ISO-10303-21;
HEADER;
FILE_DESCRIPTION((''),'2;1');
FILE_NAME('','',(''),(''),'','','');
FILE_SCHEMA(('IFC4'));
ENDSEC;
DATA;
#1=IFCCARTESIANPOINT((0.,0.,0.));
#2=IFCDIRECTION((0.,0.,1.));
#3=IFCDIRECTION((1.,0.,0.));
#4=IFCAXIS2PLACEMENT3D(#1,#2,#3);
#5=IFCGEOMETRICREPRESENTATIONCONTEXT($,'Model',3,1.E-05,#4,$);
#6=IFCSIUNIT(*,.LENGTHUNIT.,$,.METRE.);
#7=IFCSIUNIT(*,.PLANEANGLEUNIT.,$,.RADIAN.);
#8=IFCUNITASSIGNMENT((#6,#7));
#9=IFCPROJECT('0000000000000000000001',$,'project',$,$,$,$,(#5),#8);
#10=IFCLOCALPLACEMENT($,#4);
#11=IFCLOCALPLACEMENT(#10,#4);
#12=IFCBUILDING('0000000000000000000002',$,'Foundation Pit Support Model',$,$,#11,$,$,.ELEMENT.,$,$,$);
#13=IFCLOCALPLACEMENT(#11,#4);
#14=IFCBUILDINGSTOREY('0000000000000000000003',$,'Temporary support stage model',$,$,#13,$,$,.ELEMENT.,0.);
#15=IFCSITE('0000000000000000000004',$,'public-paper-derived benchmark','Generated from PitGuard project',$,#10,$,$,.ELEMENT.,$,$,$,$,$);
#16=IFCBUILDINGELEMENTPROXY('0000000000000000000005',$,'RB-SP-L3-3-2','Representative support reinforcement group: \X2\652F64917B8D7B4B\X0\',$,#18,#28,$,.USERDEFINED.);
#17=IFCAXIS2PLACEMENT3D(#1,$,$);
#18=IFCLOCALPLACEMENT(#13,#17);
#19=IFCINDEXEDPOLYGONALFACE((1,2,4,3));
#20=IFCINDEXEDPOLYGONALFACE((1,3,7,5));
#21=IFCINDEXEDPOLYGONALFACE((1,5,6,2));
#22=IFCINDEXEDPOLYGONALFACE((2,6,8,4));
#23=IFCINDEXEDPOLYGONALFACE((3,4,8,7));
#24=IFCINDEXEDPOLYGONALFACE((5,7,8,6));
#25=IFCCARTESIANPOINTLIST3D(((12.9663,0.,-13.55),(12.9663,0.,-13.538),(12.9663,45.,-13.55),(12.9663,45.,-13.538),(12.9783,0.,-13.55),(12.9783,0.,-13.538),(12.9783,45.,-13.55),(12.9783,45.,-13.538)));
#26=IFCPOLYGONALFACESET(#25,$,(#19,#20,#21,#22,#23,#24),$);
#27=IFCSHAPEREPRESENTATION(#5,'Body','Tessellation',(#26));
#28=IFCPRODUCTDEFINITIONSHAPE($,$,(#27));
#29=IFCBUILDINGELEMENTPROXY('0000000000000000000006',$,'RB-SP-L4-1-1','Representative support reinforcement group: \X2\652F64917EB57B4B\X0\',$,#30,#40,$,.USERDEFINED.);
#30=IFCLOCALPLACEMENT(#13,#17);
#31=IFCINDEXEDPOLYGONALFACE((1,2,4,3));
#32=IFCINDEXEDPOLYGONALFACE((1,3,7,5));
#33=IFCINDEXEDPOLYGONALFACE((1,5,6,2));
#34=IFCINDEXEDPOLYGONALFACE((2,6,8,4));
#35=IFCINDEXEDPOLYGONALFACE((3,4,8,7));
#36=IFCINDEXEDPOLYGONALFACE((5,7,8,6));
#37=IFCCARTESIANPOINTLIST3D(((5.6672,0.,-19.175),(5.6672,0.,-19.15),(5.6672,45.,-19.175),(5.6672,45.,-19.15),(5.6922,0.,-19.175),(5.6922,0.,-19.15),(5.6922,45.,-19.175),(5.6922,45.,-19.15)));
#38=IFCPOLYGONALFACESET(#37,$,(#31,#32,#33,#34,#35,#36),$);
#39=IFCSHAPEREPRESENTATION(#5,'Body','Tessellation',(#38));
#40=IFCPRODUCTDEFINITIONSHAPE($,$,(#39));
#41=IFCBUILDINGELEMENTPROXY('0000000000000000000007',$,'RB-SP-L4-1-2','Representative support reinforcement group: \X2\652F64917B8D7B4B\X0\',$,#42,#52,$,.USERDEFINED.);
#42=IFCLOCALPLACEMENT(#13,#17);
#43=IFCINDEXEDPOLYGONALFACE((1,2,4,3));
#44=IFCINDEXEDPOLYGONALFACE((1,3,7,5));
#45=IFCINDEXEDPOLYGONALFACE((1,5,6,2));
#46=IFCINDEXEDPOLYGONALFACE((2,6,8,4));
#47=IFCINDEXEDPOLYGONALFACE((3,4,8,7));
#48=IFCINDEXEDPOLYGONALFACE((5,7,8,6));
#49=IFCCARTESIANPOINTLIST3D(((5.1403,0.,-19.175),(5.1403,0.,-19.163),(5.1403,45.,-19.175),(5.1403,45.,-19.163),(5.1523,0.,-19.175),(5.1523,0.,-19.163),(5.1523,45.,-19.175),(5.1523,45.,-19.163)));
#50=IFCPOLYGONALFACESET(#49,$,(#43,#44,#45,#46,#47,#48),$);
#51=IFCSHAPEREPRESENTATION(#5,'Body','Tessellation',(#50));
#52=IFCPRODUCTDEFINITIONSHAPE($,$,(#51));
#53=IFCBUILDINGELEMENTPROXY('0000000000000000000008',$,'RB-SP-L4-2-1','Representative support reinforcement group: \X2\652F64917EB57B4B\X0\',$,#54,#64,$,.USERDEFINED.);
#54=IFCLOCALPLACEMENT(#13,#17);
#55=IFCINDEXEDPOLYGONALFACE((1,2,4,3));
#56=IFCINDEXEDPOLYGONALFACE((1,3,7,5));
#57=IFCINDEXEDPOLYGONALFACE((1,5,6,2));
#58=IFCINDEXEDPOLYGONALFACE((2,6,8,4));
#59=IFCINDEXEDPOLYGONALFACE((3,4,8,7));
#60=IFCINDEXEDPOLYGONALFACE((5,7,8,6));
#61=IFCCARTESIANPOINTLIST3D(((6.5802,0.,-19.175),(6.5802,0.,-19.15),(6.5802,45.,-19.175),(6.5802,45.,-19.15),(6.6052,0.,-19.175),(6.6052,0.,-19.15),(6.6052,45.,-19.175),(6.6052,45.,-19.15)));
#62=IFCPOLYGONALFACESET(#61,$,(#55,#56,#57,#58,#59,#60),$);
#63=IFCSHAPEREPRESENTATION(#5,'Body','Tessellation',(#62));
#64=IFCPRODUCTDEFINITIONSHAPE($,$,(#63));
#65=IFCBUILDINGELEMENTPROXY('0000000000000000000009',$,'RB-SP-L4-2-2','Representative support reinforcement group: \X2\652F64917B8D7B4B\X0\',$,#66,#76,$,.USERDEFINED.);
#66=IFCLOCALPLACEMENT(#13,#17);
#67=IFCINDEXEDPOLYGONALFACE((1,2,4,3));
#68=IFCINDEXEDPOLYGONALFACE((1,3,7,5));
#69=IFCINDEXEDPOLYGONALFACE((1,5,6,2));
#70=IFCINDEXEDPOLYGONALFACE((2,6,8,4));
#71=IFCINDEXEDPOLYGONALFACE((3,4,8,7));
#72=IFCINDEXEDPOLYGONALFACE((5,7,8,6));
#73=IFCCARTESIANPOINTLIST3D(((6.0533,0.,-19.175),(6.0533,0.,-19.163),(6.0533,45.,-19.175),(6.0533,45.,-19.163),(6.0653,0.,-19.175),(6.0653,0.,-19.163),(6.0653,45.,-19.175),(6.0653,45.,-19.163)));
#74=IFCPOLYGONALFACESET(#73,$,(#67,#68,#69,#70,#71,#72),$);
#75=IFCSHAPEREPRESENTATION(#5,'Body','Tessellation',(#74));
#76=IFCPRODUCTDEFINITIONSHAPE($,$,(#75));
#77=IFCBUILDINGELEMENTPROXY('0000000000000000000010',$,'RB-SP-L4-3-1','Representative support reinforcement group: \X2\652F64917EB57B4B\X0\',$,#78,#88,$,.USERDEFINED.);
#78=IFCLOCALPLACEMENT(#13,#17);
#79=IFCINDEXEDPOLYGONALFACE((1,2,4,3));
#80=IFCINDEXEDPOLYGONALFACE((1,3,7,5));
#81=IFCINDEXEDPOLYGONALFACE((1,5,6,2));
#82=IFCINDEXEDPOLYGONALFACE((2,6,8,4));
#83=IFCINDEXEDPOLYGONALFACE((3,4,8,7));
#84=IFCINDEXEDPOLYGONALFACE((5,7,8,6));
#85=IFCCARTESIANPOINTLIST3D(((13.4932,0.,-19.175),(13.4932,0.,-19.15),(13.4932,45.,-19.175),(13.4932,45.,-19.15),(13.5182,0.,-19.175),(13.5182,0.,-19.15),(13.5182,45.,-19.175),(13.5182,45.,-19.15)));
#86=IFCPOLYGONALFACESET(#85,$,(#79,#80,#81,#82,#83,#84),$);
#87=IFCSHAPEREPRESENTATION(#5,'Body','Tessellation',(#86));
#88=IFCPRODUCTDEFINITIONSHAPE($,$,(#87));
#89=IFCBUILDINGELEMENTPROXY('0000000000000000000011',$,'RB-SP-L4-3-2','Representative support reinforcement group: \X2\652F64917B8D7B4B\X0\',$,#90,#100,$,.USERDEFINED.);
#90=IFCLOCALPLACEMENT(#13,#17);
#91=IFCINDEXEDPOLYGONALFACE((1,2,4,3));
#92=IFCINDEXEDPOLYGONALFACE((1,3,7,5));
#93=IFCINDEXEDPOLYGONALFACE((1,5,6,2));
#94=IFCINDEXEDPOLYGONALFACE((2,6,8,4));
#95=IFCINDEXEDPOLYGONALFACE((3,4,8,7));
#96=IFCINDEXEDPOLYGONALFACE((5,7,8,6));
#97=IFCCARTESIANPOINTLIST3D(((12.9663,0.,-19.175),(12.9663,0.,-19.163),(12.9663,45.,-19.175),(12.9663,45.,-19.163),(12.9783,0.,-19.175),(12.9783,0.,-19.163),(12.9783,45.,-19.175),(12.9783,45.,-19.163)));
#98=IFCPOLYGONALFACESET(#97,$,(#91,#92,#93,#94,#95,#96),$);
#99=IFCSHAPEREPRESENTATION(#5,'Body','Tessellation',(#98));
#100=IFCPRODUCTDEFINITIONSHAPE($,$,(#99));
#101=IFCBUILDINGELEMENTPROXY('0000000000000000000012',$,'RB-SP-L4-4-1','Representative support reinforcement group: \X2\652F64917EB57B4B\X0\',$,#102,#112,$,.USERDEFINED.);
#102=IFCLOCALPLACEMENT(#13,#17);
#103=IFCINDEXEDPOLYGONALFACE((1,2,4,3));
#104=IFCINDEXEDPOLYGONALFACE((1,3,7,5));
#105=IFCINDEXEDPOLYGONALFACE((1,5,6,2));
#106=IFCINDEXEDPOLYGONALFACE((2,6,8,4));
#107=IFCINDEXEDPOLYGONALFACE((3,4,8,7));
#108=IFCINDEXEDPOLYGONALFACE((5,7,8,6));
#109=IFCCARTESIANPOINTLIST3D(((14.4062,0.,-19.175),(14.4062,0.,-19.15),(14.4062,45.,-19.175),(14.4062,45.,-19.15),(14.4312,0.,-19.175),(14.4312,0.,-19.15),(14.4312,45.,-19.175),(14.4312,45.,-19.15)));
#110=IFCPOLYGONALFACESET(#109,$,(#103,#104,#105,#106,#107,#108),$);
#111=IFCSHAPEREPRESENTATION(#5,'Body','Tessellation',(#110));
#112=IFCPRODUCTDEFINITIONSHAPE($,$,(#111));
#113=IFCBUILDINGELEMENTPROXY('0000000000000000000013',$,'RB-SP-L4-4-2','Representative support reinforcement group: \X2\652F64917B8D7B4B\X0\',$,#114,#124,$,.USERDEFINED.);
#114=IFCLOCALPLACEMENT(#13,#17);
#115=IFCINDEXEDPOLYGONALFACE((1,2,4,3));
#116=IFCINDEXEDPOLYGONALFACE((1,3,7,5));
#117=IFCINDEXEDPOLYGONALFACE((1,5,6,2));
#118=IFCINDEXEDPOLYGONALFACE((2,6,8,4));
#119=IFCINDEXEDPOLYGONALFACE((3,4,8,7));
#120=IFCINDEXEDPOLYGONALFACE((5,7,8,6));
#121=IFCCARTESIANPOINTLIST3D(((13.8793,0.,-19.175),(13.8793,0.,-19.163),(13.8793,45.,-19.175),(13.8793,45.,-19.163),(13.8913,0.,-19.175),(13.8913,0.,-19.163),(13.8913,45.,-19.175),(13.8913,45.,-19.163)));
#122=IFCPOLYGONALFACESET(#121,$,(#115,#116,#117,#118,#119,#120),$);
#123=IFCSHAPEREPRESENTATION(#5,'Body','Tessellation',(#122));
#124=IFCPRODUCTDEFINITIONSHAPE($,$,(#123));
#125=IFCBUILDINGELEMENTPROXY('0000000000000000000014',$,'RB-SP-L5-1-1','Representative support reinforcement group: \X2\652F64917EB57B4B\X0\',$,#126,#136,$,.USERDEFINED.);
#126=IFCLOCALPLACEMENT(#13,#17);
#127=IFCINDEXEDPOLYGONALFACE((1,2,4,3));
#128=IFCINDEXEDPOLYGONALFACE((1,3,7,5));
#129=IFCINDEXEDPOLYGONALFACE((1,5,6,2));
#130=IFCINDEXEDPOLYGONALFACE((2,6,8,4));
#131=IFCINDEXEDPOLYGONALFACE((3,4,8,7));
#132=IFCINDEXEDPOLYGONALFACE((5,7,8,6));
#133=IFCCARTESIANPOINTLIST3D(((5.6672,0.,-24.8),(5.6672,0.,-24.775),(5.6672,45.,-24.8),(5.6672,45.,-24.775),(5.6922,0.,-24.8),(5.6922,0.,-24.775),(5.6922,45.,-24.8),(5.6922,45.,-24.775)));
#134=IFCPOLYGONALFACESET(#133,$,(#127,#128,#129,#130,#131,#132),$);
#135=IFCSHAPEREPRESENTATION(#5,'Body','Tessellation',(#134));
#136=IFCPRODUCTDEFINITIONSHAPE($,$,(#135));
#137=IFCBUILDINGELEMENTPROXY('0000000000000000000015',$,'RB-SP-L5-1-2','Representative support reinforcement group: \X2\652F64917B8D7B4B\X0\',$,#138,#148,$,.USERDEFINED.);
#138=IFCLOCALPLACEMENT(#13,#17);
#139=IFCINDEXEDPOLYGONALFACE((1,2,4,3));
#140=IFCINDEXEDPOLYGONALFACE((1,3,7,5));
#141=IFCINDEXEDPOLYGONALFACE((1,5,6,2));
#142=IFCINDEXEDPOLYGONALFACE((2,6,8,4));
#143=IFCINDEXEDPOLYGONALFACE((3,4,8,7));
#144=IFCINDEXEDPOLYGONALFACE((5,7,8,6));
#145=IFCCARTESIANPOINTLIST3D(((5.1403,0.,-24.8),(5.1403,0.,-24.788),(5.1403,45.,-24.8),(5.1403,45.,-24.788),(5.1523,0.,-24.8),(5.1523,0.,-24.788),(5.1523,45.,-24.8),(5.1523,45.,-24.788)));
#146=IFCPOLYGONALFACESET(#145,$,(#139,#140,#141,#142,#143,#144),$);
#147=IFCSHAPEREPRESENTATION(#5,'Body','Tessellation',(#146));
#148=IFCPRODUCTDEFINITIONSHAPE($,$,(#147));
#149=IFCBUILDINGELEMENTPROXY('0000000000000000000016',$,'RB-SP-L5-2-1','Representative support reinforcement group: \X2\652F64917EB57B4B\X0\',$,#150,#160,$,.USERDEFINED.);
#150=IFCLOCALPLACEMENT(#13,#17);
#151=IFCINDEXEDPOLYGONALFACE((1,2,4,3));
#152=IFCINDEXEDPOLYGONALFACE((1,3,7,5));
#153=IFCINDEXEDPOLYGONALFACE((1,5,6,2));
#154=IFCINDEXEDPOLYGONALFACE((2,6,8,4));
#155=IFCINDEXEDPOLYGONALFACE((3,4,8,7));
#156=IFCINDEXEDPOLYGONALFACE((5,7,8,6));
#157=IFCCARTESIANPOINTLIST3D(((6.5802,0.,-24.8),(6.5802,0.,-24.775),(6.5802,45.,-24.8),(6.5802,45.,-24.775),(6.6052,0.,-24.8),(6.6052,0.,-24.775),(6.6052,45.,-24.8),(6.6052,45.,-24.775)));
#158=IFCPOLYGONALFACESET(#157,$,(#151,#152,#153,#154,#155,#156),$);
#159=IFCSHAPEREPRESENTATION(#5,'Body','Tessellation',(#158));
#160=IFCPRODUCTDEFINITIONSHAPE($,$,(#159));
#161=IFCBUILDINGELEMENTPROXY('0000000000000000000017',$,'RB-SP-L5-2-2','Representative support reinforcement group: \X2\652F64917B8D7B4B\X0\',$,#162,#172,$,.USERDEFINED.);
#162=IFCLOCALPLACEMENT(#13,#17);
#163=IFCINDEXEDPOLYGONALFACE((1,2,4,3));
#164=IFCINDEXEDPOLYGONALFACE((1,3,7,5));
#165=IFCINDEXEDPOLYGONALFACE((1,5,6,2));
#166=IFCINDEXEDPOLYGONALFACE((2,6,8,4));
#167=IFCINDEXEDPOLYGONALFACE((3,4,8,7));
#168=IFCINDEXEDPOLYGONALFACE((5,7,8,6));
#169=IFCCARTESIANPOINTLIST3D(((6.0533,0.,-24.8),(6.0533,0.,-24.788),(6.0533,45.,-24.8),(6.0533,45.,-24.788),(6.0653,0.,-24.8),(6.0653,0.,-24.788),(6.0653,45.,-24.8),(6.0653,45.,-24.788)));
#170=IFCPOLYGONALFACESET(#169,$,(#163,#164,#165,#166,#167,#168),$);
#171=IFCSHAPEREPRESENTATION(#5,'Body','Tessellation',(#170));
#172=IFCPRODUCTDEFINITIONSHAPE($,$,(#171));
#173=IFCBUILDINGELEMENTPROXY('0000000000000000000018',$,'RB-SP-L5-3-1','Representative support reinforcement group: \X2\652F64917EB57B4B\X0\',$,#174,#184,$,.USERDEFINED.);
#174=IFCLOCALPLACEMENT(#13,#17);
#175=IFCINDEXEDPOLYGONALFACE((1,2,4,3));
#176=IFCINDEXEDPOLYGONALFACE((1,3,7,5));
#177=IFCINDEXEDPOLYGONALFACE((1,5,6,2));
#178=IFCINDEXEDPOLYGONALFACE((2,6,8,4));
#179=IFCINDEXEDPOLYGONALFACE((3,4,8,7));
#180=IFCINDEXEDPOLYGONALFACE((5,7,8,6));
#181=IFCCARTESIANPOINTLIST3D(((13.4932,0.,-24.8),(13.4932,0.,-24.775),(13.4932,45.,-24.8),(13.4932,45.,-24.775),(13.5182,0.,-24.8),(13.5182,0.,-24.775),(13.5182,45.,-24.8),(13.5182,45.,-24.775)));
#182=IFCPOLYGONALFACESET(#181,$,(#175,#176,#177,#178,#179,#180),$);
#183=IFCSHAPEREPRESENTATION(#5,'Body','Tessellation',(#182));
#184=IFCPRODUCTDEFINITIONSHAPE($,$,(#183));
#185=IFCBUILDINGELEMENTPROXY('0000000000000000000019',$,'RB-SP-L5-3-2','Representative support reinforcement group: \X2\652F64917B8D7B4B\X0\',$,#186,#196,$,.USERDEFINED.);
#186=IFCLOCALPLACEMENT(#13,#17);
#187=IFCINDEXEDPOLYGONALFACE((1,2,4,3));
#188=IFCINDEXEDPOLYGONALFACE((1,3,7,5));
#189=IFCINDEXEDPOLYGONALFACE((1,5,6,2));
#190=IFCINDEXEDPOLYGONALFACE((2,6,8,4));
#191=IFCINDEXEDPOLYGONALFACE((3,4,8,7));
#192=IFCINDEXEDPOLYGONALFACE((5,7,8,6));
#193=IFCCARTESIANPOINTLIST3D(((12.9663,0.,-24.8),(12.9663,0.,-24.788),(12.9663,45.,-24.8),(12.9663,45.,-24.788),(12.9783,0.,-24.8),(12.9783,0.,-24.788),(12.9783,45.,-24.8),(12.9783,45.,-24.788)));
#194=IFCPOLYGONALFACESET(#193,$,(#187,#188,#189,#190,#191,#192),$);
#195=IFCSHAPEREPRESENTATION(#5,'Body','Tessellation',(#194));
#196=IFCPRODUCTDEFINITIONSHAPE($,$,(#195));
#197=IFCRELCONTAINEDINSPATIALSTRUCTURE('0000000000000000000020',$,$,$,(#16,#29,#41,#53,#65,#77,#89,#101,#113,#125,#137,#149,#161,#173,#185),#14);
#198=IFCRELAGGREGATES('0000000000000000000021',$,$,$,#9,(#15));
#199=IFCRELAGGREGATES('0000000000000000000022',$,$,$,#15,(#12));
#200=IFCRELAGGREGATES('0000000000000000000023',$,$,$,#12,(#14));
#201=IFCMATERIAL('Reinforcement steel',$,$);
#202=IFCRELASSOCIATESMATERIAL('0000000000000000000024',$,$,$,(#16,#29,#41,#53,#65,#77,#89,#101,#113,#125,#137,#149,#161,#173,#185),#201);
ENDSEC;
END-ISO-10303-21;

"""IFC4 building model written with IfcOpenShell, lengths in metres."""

from ifc_helpers import new_model, si_unit, frame, origin_with_axes, origin_2d, place, context, project, spatial, rectangle, extrude, material, element, save


model = new_model("IFC4")

# Units and contexts
model_context = context("Model", 3, precision=1e-05, world=origin_with_axes())
ifc_project = project(units=[si_unit("LENGTHUNIT", "METRE"), si_unit("PLANEANGLEUNIT", "RADIAN")], contexts=[model_context])

# Site, building, storey
site_placement = place(None, origin_with_axes())
site = spatial("IfcSite", under=ifc_project, at=site_placement, Name="public-paper-derived benchmark", Description="Generated from PitGuard project", CompositionType="ELEMENT")
building_placement = place(site_placement, origin_with_axes())
building = spatial("IfcBuilding", under=site, at=building_placement, Name="Foundation Pit Support Model", CompositionType="ELEMENT")
storey_placement = place(building_placement, origin_with_axes())
storey = spatial("IfcBuildingStorey", under=building, at=storey_placement, Name="Temporary support stage model", CompositionType="ELEMENT", Elevation=0.0)

# Building element proxies
ifc_material_1 = material(Name="Reinforcement steel")
proxy_1_placement = place(storey_placement, frame((12.9723, 22.5, -13.55), z_axis=(0.0, 0.0, 1.0), x_axis=(0.0, 1.0, 0.0)))
element("IfcBuildingElementProxy", 1, at=proxy_1_placement, inside=storey, material=ifc_material_1, Name="RB-SP-L3-3-2", Description="Representative support reinforcement group: 支撑箍筋", PredefinedType="USERDEFINED", context=model_context, shape_type="SweptSolid", body=[
    extrude(rectangle(XDim=45.0, YDim=0.012, at=origin_2d()), origin_with_axes(), (0.0, 0.0, 1.0), 0.012),
])
proxy_2_placement = place(storey_placement, frame((5.6797, 22.5, -19.175), z_axis=(0.0, 0.0, 1.0), x_axis=(0.0, 1.0, 0.0)))
element("IfcBuildingElementProxy", 2, at=proxy_2_placement, inside=storey, material=ifc_material_1, Name="RB-SP-L4-1-1", Description="Representative support reinforcement group: 支撑纵筋", PredefinedType="USERDEFINED", context=model_context, shape_type="SweptSolid", body=[
    extrude(rectangle(XDim=45.0, YDim=0.025, at=origin_2d()), origin_with_axes(), (0.0, 0.0, 1.0), 0.025),
])
proxy_3_placement = place(storey_placement, frame((5.1463, 22.5, -19.175), z_axis=(0.0, 0.0, 1.0), x_axis=(0.0, 1.0, 0.0)))
element("IfcBuildingElementProxy", 3, at=proxy_3_placement, inside=storey, material=ifc_material_1, Name="RB-SP-L4-1-2", Description="Representative support reinforcement group: 支撑箍筋", PredefinedType="USERDEFINED", context=model_context, shape_type="SweptSolid", body=[
    extrude(rectangle(XDim=45.0, YDim=0.012, at=origin_2d()), origin_with_axes(), (0.0, 0.0, 1.0), 0.012),
])
proxy_4_placement = place(storey_placement, frame((6.5927, 22.5, -19.175), z_axis=(0.0, 0.0, 1.0), x_axis=(0.0, 1.0, 0.0)))
element("IfcBuildingElementProxy", 4, at=proxy_4_placement, inside=storey, material=ifc_material_1, Name="RB-SP-L4-2-1", Description="Representative support reinforcement group: 支撑纵筋", PredefinedType="USERDEFINED", context=model_context, shape_type="SweptSolid", body=[
    extrude(rectangle(XDim=45.0, YDim=0.025, at=origin_2d()), origin_with_axes(), (0.0, 0.0, 1.0), 0.025),
])
proxy_5_placement = place(storey_placement, frame((6.0593, 22.5, -19.175), z_axis=(0.0, 0.0, 1.0), x_axis=(0.0, 1.0, 0.0)))
element("IfcBuildingElementProxy", 5, at=proxy_5_placement, inside=storey, material=ifc_material_1, Name="RB-SP-L4-2-2", Description="Representative support reinforcement group: 支撑箍筋", PredefinedType="USERDEFINED", context=model_context, shape_type="SweptSolid", body=[
    extrude(rectangle(XDim=45.0, YDim=0.012, at=origin_2d()), origin_with_axes(), (0.0, 0.0, 1.0), 0.012),
])
proxy_6_placement = place(storey_placement, frame((13.5057, 22.5, -19.175), z_axis=(0.0, 0.0, 1.0), x_axis=(0.0, 1.0, 0.0)))
element("IfcBuildingElementProxy", 6, at=proxy_6_placement, inside=storey, material=ifc_material_1, Name="RB-SP-L4-3-1", Description="Representative support reinforcement group: 支撑纵筋", PredefinedType="USERDEFINED", context=model_context, shape_type="SweptSolid", body=[
    extrude(rectangle(XDim=45.0, YDim=0.025, at=origin_2d()), origin_with_axes(), (0.0, 0.0, 1.0), 0.025),
])
proxy_7_placement = place(storey_placement, frame((12.9723, 22.5, -19.175), z_axis=(0.0, 0.0, 1.0), x_axis=(0.0, 1.0, 0.0)))
element("IfcBuildingElementProxy", 7, at=proxy_7_placement, inside=storey, material=ifc_material_1, Name="RB-SP-L4-3-2", Description="Representative support reinforcement group: 支撑箍筋", PredefinedType="USERDEFINED", context=model_context, shape_type="SweptSolid", body=[
    extrude(rectangle(XDim=45.0, YDim=0.012, at=origin_2d()), origin_with_axes(), (0.0, 0.0, 1.0), 0.012),
])
proxy_8_placement = place(storey_placement, frame((14.4187, 22.5, -19.175), z_axis=(0.0, 0.0, 1.0), x_axis=(0.0, 1.0, 0.0)))
element("IfcBuildingElementProxy", 8, at=proxy_8_placement, inside=storey, material=ifc_material_1, Name="RB-SP-L4-4-1", Description="Representative support reinforcement group: 支撑纵筋", PredefinedType="USERDEFINED", context=model_context, shape_type="SweptSolid", body=[
    extrude(rectangle(XDim=45.0, YDim=0.025, at=origin_2d()), origin_with_axes(), (0.0, 0.0, 1.0), 0.025),
])
proxy_9_placement = place(storey_placement, frame((13.8853, 22.5, -19.175), z_axis=(0.0, 0.0, 1.0), x_axis=(0.0, 1.0, 0.0)))
element("IfcBuildingElementProxy", 9, at=proxy_9_placement, inside=storey, material=ifc_material_1, Name="RB-SP-L4-4-2", Description="Representative support reinforcement group: 支撑箍筋", PredefinedType="USERDEFINED", context=model_context, shape_type="SweptSolid", body=[
    extrude(rectangle(XDim=45.0, YDim=0.012, at=origin_2d()), origin_with_axes(), (0.0, 0.0, 1.0), 0.012),
])
proxy_10_placement = place(storey_placement, frame((5.6797, 22.5, -24.8), z_axis=(0.0, 0.0, 1.0), x_axis=(0.0, 1.0, 0.0)))
element("IfcBuildingElementProxy", 10, at=proxy_10_placement, inside=storey, material=ifc_material_1, Name="RB-SP-L5-1-1", Description="Representative support reinforcement group: 支撑纵筋", PredefinedType="USERDEFINED", context=model_context, shape_type="SweptSolid", body=[
    extrude(rectangle(XDim=45.0, YDim=0.025, at=origin_2d()), origin_with_axes(), (0.0, 0.0, 1.0), 0.025),
])
proxy_11_placement = place(storey_placement, frame((5.1463, 22.5, -24.8), z_axis=(0.0, 0.0, 1.0), x_axis=(0.0, 1.0, 0.0)))
element("IfcBuildingElementProxy", 11, at=proxy_11_placement, inside=storey, material=ifc_material_1, Name="RB-SP-L5-1-2", Description="Representative support reinforcement group: 支撑箍筋", PredefinedType="USERDEFINED", context=model_context, shape_type="SweptSolid", body=[
    extrude(rectangle(XDim=45.0, YDim=0.012, at=origin_2d()), origin_with_axes(), (0.0, 0.0, 1.0), 0.012),
])
proxy_12_placement = place(storey_placement, frame((6.5927, 22.5, -24.8), z_axis=(0.0, 0.0, 1.0), x_axis=(0.0, 1.0, 0.0)))
element("IfcBuildingElementProxy", 12, at=proxy_12_placement, inside=storey, material=ifc_material_1, Name="RB-SP-L5-2-1", Description="Representative support reinforcement group: 支撑纵筋", PredefinedType="USERDEFINED", context=model_context, shape_type="SweptSolid", body=[
    extrude(rectangle(XDim=45.0, YDim=0.025, at=origin_2d()), origin_with_axes(), (0.0, 0.0, 1.0), 0.025),
])
proxy_13_placement = place(storey_placement, frame((6.0593, 22.5, -24.8), z_axis=(0.0, 0.0, 1.0), x_axis=(0.0, 1.0, 0.0)))
element("IfcBuildingElementProxy", 13, at=proxy_13_placement, inside=storey, material=ifc_material_1, Name="RB-SP-L5-2-2", Description="Representative support reinforcement group: 支撑箍筋", PredefinedType="USERDEFINED", context=model_context, shape_type="SweptSolid", body=[
    extrude(rectangle(XDim=45.0, YDim=0.012, at=origin_2d()), origin_with_axes(), (0.0, 0.0, 1.0), 0.012),
])
proxy_14_placement = place(storey_placement, frame((13.5057, 22.5, -24.8), z_axis=(0.0, 0.0, 1.0), x_axis=(0.0, 1.0, 0.0)))
element("IfcBuildingElementProxy", 14, at=proxy_14_placement, inside=storey, material=ifc_material_1, Name="RB-SP-L5-3-1", Description="Representative support reinforcement group: 支撑纵筋", PredefinedType="USERDEFINED", context=model_context, shape_type="SweptSolid", body=[
    extrude(rectangle(XDim=45.0, YDim=0.025, at=origin_2d()), origin_with_axes(), (0.0, 0.0, 1.0), 0.025),
])
for number, where, z_axis, x_axis, name in (
    (15, (12.9723, 22.5, -24.8), (0.0, 0.0, 1.0), (0.0, 1.0, 0.0), "RB-SP-L5-3-2"),
):
    element("IfcBuildingElementProxy", number, at=place(storey_placement, frame(where, z_axis=z_axis, x_axis=x_axis)), inside=storey, material=ifc_material_1, Name=name, Description="Representative support reinforcement group: 支撑箍筋", PredefinedType="USERDEFINED", context=model_context, shape_type="SweptSolid", body=[
        extrude(rectangle(XDim=45.0, YDim=0.012, at=origin_2d()), origin_with_axes(), (0.0, 0.0, 1.0), 0.012),
    ])

save(model, "model.ifc")
